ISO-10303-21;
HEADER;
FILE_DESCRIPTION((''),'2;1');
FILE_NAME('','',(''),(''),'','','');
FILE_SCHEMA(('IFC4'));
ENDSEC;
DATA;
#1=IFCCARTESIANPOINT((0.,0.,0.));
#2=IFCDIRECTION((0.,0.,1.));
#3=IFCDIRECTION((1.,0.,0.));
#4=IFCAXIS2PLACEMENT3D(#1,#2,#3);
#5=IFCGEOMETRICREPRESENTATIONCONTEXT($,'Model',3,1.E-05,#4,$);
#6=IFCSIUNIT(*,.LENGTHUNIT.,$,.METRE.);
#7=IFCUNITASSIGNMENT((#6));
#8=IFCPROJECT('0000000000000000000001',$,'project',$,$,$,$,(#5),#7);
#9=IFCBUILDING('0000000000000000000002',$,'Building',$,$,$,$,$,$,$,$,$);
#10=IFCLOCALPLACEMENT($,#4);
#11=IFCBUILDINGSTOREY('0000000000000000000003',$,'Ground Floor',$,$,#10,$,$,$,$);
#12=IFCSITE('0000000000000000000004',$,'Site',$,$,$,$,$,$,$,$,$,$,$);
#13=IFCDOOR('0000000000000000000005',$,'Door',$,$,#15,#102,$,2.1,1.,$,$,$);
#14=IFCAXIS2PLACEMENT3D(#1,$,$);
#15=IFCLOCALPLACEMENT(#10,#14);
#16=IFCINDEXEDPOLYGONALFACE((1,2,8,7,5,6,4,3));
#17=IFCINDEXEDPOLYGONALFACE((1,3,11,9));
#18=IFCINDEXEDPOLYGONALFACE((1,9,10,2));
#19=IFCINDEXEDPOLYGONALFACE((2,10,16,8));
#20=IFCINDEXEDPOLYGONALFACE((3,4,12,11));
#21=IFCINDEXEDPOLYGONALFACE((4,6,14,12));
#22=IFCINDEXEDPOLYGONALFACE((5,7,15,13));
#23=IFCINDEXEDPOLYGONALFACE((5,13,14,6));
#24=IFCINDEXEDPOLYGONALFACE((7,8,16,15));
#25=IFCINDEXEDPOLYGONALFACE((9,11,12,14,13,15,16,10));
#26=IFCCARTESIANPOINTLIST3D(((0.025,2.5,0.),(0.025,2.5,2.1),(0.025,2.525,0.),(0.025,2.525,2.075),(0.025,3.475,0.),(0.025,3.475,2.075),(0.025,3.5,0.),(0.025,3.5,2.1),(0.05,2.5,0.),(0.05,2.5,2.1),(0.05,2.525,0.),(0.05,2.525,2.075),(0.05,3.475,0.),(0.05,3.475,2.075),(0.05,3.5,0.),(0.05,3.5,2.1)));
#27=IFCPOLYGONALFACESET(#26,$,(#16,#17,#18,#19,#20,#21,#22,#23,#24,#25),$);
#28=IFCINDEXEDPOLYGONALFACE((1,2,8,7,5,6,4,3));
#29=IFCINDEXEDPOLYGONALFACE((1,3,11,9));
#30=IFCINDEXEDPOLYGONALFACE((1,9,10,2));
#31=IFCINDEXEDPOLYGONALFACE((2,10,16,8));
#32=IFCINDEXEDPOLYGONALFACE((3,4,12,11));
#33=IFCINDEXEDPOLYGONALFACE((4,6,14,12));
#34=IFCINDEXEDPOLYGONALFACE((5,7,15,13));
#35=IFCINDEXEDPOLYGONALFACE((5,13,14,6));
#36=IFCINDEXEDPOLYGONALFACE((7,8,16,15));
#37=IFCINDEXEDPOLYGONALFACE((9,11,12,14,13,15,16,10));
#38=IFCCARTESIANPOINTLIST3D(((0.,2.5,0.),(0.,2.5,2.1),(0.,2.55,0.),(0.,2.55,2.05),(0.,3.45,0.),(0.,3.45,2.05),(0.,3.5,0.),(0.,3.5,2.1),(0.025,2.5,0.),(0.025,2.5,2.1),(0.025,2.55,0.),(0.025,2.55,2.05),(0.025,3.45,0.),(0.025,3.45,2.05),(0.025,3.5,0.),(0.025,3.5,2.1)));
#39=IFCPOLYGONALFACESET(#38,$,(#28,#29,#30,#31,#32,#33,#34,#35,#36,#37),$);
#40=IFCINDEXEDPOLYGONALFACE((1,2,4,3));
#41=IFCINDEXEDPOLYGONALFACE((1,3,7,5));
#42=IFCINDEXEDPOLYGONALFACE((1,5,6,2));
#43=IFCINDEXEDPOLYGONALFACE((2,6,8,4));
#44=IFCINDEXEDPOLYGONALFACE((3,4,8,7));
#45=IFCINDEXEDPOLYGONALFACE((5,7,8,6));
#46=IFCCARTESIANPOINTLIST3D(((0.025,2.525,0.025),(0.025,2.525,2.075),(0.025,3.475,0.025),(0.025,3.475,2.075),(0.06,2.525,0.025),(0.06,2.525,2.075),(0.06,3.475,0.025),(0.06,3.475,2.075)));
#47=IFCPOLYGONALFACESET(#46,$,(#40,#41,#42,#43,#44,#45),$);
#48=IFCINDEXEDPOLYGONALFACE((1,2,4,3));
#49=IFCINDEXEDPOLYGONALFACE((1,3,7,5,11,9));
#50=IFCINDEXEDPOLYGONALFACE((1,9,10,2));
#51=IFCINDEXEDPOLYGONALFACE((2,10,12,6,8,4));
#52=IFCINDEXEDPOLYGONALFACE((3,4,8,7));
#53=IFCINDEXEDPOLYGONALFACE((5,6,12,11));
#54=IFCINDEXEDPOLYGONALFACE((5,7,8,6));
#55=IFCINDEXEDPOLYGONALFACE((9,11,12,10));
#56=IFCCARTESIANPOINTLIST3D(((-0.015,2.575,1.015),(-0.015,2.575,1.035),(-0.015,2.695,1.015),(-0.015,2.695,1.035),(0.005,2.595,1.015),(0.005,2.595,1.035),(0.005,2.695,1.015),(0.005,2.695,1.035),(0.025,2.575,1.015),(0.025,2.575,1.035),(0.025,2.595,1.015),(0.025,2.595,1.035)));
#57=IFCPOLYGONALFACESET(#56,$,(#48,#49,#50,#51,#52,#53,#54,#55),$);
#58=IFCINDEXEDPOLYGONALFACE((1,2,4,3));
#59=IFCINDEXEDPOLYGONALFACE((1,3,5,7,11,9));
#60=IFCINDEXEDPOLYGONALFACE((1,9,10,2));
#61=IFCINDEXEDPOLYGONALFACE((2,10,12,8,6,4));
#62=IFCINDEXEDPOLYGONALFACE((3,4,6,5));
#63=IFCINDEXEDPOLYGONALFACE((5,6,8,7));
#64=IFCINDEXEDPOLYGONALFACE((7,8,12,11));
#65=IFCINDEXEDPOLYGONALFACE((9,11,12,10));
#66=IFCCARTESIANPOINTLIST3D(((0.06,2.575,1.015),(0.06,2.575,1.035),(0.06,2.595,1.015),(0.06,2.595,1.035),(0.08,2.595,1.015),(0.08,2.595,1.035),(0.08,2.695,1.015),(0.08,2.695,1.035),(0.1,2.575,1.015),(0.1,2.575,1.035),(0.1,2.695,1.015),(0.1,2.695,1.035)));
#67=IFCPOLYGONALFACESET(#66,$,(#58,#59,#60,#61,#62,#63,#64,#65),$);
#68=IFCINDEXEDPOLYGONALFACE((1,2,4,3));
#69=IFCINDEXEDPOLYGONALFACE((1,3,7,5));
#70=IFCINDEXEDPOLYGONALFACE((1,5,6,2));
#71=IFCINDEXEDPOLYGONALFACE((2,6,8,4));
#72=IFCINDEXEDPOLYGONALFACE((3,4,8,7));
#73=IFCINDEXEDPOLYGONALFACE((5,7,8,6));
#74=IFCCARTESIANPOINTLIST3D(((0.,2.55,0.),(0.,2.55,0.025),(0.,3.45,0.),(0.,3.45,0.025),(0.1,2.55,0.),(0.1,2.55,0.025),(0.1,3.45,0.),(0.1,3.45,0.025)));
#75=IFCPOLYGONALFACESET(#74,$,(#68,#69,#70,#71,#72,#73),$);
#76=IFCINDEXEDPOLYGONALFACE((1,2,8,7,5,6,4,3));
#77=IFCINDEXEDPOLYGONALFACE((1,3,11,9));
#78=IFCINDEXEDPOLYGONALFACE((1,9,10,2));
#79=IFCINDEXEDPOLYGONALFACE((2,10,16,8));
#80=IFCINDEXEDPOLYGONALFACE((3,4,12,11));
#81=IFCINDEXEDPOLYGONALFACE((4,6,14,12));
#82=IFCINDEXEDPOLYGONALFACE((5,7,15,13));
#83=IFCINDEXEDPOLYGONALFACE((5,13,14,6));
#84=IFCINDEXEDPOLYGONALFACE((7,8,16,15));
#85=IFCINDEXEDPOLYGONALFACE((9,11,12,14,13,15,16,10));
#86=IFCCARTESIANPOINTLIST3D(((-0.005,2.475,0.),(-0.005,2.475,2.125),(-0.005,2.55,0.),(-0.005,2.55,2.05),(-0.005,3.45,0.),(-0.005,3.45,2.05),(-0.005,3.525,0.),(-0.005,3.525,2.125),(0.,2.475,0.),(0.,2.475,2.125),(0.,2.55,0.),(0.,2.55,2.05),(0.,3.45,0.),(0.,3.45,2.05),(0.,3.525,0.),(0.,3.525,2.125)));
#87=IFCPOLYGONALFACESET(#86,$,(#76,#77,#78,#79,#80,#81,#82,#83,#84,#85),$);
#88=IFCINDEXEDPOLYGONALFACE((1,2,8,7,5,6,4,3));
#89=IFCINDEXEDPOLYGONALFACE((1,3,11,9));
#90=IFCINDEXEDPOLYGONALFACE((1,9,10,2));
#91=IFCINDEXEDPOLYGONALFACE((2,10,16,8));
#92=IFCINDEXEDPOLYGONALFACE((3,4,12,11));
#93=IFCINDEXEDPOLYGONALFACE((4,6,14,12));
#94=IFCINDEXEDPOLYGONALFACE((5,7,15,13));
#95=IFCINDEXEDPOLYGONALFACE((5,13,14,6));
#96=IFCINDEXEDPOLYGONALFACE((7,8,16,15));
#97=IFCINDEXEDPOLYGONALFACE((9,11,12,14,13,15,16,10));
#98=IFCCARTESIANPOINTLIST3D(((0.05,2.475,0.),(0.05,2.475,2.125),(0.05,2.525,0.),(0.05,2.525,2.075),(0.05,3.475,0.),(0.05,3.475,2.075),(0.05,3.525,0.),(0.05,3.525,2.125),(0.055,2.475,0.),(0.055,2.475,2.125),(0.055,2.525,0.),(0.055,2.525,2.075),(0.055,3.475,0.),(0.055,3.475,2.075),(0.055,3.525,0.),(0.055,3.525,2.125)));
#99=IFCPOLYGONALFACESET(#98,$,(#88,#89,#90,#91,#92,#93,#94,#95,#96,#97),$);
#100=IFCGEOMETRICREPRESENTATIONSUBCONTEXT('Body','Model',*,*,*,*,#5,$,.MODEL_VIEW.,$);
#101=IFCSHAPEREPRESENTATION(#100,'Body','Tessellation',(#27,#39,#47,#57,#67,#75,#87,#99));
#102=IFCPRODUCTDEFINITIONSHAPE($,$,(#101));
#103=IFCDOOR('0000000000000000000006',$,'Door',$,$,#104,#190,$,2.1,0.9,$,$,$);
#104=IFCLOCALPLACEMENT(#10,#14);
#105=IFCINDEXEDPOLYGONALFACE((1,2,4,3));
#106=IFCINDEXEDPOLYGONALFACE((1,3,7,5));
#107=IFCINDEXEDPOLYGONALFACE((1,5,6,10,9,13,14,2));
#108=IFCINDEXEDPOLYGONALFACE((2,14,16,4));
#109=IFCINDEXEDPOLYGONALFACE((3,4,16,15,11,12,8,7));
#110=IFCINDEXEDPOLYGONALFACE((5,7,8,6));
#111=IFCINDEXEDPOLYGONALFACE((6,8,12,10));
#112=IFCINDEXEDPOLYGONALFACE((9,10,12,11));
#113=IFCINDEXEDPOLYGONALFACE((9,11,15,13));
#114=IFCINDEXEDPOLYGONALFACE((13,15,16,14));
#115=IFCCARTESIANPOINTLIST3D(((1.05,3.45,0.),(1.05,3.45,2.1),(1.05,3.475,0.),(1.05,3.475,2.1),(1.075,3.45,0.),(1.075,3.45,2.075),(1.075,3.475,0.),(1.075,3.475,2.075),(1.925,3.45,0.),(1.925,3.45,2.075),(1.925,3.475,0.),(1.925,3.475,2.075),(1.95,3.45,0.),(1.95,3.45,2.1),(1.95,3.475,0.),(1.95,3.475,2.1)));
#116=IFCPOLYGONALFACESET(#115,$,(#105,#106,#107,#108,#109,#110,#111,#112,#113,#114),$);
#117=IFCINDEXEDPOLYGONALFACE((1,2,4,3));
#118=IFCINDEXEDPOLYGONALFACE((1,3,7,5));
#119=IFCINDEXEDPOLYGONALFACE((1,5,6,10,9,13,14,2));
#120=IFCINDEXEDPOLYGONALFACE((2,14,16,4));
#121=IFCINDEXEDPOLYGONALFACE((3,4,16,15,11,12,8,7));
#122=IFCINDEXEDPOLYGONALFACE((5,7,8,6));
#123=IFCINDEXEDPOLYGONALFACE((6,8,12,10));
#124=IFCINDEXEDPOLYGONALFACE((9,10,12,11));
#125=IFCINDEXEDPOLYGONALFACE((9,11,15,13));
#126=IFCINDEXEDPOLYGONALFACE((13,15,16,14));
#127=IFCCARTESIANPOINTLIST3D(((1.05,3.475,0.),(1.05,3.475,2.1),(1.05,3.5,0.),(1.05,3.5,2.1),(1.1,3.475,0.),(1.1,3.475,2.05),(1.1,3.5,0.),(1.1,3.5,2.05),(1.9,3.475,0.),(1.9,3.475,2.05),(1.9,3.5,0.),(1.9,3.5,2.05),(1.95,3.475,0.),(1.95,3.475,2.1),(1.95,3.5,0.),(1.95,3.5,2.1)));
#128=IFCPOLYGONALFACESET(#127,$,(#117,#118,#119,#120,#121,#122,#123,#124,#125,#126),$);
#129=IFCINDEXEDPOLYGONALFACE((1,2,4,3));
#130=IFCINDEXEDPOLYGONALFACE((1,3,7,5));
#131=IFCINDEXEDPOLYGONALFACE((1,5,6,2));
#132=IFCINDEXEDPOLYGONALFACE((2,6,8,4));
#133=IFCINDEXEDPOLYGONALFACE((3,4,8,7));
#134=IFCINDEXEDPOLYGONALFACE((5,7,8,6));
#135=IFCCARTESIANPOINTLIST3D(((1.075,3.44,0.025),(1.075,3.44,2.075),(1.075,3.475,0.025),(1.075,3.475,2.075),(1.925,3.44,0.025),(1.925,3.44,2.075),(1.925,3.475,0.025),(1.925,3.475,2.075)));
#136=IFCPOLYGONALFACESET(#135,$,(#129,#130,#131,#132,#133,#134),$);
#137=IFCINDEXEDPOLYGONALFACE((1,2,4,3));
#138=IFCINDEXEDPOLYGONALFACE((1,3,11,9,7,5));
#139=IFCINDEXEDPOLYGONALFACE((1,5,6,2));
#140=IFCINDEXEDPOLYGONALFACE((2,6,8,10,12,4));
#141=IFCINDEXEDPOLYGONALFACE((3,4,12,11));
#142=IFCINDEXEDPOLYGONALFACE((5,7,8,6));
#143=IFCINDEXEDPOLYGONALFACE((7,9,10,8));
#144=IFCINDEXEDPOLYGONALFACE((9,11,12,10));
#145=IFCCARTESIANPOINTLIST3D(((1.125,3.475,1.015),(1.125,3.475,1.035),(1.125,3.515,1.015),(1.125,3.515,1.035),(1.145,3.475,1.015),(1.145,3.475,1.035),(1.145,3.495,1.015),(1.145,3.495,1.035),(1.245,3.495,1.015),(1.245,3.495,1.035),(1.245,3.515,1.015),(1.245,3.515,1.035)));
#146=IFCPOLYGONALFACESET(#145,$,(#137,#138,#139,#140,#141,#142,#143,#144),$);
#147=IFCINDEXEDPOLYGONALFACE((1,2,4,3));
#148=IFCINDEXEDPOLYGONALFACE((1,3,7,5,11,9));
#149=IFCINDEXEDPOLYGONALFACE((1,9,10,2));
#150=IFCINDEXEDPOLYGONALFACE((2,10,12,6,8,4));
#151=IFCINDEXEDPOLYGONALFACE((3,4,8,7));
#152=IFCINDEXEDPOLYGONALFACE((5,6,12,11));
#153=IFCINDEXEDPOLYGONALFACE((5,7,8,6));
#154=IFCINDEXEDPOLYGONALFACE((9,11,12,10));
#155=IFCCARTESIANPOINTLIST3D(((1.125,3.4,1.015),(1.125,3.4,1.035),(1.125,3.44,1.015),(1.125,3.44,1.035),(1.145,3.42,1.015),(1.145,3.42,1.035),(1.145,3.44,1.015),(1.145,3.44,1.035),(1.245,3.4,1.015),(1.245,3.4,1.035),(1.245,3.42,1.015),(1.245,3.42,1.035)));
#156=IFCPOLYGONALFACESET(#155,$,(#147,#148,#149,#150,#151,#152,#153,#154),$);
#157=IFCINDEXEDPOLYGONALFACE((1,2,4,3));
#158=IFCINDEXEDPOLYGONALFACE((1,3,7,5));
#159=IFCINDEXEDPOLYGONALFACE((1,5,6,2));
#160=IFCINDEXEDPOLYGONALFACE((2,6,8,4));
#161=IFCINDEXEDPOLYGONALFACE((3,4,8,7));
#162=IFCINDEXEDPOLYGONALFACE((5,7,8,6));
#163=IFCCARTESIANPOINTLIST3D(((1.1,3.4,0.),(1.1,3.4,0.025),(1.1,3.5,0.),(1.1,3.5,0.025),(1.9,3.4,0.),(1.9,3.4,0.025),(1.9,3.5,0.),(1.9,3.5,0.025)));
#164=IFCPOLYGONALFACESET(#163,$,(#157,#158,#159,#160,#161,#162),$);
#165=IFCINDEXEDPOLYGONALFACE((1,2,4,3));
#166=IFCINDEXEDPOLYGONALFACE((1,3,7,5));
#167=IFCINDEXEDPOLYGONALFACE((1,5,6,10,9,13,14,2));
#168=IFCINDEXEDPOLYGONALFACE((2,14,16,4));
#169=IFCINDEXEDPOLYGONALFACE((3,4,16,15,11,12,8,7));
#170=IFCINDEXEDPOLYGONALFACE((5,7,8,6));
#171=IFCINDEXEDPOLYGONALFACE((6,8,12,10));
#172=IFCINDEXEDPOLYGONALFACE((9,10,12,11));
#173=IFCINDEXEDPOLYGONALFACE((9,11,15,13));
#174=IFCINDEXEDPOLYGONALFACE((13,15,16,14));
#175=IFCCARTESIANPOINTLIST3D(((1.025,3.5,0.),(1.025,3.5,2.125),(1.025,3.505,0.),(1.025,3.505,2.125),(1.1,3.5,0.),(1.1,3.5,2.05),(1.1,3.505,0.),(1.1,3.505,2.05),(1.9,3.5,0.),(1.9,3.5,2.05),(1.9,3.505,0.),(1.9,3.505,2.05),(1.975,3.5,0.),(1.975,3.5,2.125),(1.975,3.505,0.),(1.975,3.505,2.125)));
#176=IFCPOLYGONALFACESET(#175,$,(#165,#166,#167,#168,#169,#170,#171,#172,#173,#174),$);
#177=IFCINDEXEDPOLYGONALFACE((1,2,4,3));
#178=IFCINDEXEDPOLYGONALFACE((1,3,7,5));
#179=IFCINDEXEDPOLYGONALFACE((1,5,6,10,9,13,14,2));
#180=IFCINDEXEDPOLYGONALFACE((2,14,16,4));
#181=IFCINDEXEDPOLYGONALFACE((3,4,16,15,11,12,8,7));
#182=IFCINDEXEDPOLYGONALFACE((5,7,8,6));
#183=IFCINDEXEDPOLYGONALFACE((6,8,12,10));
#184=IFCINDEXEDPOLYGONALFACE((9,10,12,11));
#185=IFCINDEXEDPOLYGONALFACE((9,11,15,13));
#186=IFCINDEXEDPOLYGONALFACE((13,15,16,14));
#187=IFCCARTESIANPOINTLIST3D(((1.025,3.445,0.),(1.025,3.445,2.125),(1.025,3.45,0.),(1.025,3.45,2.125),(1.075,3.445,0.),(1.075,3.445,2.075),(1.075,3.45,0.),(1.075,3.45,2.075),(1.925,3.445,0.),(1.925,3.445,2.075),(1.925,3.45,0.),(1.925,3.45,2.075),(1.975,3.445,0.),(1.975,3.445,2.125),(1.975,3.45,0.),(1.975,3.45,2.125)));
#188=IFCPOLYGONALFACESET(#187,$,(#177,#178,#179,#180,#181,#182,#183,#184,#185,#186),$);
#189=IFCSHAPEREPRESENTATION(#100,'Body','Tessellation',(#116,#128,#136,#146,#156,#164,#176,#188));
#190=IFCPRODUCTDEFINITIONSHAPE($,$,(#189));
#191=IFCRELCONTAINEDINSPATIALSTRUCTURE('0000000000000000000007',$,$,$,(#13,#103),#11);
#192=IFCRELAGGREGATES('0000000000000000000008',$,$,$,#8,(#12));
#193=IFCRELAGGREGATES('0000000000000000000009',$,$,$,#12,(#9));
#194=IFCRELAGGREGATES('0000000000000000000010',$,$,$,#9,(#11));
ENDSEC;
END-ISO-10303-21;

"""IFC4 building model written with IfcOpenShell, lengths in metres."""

from ifc_helpers import new_model, si_unit, frame, origin_with_axes, place, context, subcontext, project, spatial, line, indexed_curve, outline, extrude, element, save


model = new_model("IFC4")

# Units and contexts
model_context = context("Model", 3, precision=1e-05, world=origin_with_axes())
body_context = subcontext(model_context, "Body", "Model", "MODEL_VIEW")
ifc_project = project(units=[si_unit("LENGTHUNIT", "METRE")], contexts=[model_context])

# Site, building, storey
site = spatial("IfcSite", under=ifc_project, Name="Site")
building = spatial("IfcBuilding", under=site, Name="Building")
storey_placement = place(None, origin_with_axes())
storey = spatial("IfcBuildingStorey", under=building, at=storey_placement, Name="Ground Floor")

# Doors
door_1_placement = place(storey_placement, frame((0.0, 3.5, 0.0), z_axis=(0.0, 0.0, 1.0), x_axis=(0.0, -1.0, 0.0)))
element("IfcDoor", 1, at=door_1_placement, inside=storey, Name="Door", OverallHeight=2.1, OverallWidth=1.0, context=body_context, shape_type="SweptSolid", body=[
    extrude(outline(indexed_curve([(0.0, 0.0), (0.0, 2.1), (1.0, 2.1), (1.0, 0.0), (0.975, 0.0), (0.975, 2.075), (0.025, 2.075), (0.025, 0.0)], segments=[line(1, 2, 3, 4, 5, 6, 7, 8, 1)])), frame((0.0, 0.025, 0.0), z_axis=(0.0, -1.0, 0.0), x_axis=(1.0, 0.0, 0.0)), (0.0, 0.0, -1.0), 0.025),
    extrude(outline(indexed_curve([(0.0, 0.0), (0.0, 2.1), (1.0, 2.1), (1.0, 0.0), (0.95, 0.0), (0.95, 2.05), (0.05, 2.05), (0.05, 0.0)], segments=[line(1, 2, 3, 4, 5, 6, 7, 8, 1)])), frame((0.0, 0.0, 0.0), z_axis=(0.0, -1.0, 0.0), x_axis=(1.0, 0.0, 0.0)), (0.0, 0.0, -1.0), 0.025),
    extrude(outline(indexed_curve([(0.0, 0.0), (0.95, 0.0), (0.95, 0.035), (0.0, 0.035)], segments=[line(1, 2, 3, 4, 1)])), frame((0.025, 0.025, 0.025), z_axis=(0.0, 0.0, 1.0), x_axis=(1.0, 0.0, 0.0)), (0.0, 0.0, 1.0), 2.05),
    extrude(outline(indexed_curve([(0.0, 0.0), (0.0, -0.04), (-0.12, -0.04), (-0.12, -0.02), (-0.02, -0.02), (-0.02, 0.0)], segments=[line(1, 2, 3, 4, 5, 6, 1)])), frame((0.925, 0.025, 1.015), z_axis=(0.0, 0.0, 1.0), x_axis=(1.0, 0.0, 0.0)), (0.0, 0.0, 1.0), 0.02),
    extrude(outline(indexed_curve([(0.0, 0.0), (0.0, 0.04), (-0.12, 0.04), (-0.12, 0.02), (-0.02, 0.02), (-0.02, 0.0)], segments=[line(1, 2, 3, 4, 5, 6, 1)])), frame((0.925, 0.06, 1.015), z_axis=(0.0, 0.0, 1.0), x_axis=(1.0, 0.0, 0.0)), (0.0, 0.0, 1.0), 0.02),
    extrude(outline(indexed_curve([(0.0, 0.0), (0.9, 0.0), (0.9, 0.1), (0.0, 0.1)], segments=[line(1, 2, 3, 4, 1)])), frame((0.05, 0.0, 0.0), z_axis=(0.0, 0.0, 1.0), x_axis=(1.0, 0.0, 0.0)), (0.0, 0.0, 1.0), 0.025),
    extrude(outline(indexed_curve([(0.0, 0.0), (0.0, 2.125), (1.05, 2.125), (1.05, 0.0), (0.975, 0.0), (0.975, 2.05), (0.075, 2.05), (0.075, 0.0)], segments=[line(1, 2, 3, 4, 5, 6, 7, 8, 1)])), frame((-0.025, -0.005, 0.0), z_axis=(0.0, -1.0, 0.0), x_axis=(1.0, 0.0, 0.0)), (0.0, 0.0, -1.0), 0.005),
    extrude(outline(indexed_curve([(0.0, 0.0), (0.0, 2.125), (1.05, 2.125), (1.05, 0.0), (1.0, 0.0), (1.0, 2.075), (0.05, 2.075), (0.05, 0.0)], segments=[line(1, 2, 3, 4, 5, 6, 7, 8, 1)])), frame((-0.025, 0.05, 0.0), z_axis=(0.0, -1.0, 0.0), x_axis=(1.0, 0.0, 0.0)), (0.0, 0.0, -1.0), 0.005),
])
door_2_placement = place(storey_placement, frame((1.95, 3.5, 0.0), z_axis=(0.0, 0.0, 1.0), x_axis=(-1.0, 0.0, 0.0)))
element("IfcDoor", 2, at=door_2_placement, inside=storey, Name="Door", OverallHeight=2.1, OverallWidth=0.9, context=body_context, shape_type="SweptSolid", body=[
    extrude(outline(indexed_curve([(0.0, 0.0), (0.0, 2.1), (0.9, 2.1), (0.9, 0.0), (0.875, 0.0), (0.875, 2.075), (0.025, 2.075), (0.025, 0.0)], segments=[line(1, 2, 3, 4, 5, 6, 7, 8, 1)])), frame((0.0, 0.025, 0.0), z_axis=(0.0, -1.0, 0.0), x_axis=(1.0, 0.0, 0.0)), (0.0, 0.0, -1.0), 0.025),
    extrude(outline(indexed_curve([(0.0, 0.0), (0.0, 2.1), (0.9, 2.1), (0.9, 0.0), (0.85, 0.0), (0.85, 2.05), (0.05, 2.05), (0.05, 0.0)], segments=[line(1, 2, 3, 4, 5, 6, 7, 8, 1)])), frame((0.0, 0.0, 0.0), z_axis=(0.0, -1.0, 0.0), x_axis=(1.0, 0.0, 0.0)), (0.0, 0.0, -1.0), 0.025),
    extrude(outline(indexed_curve([(0.0, 0.0), (0.85, 0.0), (0.85, 0.035), (0.0, 0.035)], segments=[line(1, 2, 3, 4, 1)])), frame((0.025, 0.025, 0.025), z_axis=(0.0, 0.0, 1.0), x_axis=(1.0, 0.0, 0.0)), (0.0, 0.0, 1.0), 2.05),
    extrude(outline(indexed_curve([(0.0, 0.0), (0.0, -0.04), (-0.12, -0.04), (-0.12, -0.02), (-0.02, -0.02), (-0.02, 0.0)], segments=[line(1, 2, 3, 4, 5, 6, 1)])), frame((0.825, 0.025, 1.015), z_axis=(0.0, 0.0, 1.0), x_axis=(1.0, 0.0, 0.0)), (0.0, 0.0, 1.0), 0.02),
    extrude(outline(indexed_curve([(0.0, 0.0), (0.0, 0.04), (-0.12, 0.04), (-0.12, 0.02), (-0.02, 0.02), (-0.02, 0.0)], segments=[line(1, 2, 3, 4, 5, 6, 1)])), frame((0.825, 0.06, 1.015), z_axis=(0.0, 0.0, 1.0), x_axis=(1.0, 0.0, 0.0)), (0.0, 0.0, 1.0), 0.02),
    extrude(outline(indexed_curve([(0.0, 0.0), (0.8, 0.0), (0.8, 0.1), (0.0, 0.1)], segments=[line(1, 2, 3, 4, 1)])), frame((0.05, 0.0, 0.0), z_axis=(0.0, 0.0, 1.0), x_axis=(1.0, 0.0, 0.0)), (0.0, 0.0, 1.0), 0.025),
    extrude(outline(indexed_curve([(0.0, 0.0), (0.0, 2.125), (0.95, 2.125), (0.95, 0.0), (0.875, 0.0), (0.875, 2.05), (0.075, 2.05), (0.075, 0.0)], segments=[line(1, 2, 3, 4, 5, 6, 7, 8, 1)])), frame((-0.025, -0.005, 0.0), z_axis=(0.0, -1.0, 0.0), x_axis=(1.0, 0.0, 0.0)), (0.0, 0.0, -1.0), 0.005),
    extrude(outline(indexed_curve([(0.0, 0.0), (0.0, 2.125), (0.95, 2.125), (0.95, 0.0), (0.9, 0.0), (0.9, 2.075), (0.05, 2.075), (0.05, 0.0)], segments=[line(1, 2, 3, 4, 5, 6, 7, 8, 1)])), frame((-0.025, 0.05, 0.0), z_axis=(0.0, -1.0, 0.0), x_axis=(1.0, 0.0, 0.0)), (0.0, 0.0, -1.0), 0.005),
])

save(model, "model.ifc")
